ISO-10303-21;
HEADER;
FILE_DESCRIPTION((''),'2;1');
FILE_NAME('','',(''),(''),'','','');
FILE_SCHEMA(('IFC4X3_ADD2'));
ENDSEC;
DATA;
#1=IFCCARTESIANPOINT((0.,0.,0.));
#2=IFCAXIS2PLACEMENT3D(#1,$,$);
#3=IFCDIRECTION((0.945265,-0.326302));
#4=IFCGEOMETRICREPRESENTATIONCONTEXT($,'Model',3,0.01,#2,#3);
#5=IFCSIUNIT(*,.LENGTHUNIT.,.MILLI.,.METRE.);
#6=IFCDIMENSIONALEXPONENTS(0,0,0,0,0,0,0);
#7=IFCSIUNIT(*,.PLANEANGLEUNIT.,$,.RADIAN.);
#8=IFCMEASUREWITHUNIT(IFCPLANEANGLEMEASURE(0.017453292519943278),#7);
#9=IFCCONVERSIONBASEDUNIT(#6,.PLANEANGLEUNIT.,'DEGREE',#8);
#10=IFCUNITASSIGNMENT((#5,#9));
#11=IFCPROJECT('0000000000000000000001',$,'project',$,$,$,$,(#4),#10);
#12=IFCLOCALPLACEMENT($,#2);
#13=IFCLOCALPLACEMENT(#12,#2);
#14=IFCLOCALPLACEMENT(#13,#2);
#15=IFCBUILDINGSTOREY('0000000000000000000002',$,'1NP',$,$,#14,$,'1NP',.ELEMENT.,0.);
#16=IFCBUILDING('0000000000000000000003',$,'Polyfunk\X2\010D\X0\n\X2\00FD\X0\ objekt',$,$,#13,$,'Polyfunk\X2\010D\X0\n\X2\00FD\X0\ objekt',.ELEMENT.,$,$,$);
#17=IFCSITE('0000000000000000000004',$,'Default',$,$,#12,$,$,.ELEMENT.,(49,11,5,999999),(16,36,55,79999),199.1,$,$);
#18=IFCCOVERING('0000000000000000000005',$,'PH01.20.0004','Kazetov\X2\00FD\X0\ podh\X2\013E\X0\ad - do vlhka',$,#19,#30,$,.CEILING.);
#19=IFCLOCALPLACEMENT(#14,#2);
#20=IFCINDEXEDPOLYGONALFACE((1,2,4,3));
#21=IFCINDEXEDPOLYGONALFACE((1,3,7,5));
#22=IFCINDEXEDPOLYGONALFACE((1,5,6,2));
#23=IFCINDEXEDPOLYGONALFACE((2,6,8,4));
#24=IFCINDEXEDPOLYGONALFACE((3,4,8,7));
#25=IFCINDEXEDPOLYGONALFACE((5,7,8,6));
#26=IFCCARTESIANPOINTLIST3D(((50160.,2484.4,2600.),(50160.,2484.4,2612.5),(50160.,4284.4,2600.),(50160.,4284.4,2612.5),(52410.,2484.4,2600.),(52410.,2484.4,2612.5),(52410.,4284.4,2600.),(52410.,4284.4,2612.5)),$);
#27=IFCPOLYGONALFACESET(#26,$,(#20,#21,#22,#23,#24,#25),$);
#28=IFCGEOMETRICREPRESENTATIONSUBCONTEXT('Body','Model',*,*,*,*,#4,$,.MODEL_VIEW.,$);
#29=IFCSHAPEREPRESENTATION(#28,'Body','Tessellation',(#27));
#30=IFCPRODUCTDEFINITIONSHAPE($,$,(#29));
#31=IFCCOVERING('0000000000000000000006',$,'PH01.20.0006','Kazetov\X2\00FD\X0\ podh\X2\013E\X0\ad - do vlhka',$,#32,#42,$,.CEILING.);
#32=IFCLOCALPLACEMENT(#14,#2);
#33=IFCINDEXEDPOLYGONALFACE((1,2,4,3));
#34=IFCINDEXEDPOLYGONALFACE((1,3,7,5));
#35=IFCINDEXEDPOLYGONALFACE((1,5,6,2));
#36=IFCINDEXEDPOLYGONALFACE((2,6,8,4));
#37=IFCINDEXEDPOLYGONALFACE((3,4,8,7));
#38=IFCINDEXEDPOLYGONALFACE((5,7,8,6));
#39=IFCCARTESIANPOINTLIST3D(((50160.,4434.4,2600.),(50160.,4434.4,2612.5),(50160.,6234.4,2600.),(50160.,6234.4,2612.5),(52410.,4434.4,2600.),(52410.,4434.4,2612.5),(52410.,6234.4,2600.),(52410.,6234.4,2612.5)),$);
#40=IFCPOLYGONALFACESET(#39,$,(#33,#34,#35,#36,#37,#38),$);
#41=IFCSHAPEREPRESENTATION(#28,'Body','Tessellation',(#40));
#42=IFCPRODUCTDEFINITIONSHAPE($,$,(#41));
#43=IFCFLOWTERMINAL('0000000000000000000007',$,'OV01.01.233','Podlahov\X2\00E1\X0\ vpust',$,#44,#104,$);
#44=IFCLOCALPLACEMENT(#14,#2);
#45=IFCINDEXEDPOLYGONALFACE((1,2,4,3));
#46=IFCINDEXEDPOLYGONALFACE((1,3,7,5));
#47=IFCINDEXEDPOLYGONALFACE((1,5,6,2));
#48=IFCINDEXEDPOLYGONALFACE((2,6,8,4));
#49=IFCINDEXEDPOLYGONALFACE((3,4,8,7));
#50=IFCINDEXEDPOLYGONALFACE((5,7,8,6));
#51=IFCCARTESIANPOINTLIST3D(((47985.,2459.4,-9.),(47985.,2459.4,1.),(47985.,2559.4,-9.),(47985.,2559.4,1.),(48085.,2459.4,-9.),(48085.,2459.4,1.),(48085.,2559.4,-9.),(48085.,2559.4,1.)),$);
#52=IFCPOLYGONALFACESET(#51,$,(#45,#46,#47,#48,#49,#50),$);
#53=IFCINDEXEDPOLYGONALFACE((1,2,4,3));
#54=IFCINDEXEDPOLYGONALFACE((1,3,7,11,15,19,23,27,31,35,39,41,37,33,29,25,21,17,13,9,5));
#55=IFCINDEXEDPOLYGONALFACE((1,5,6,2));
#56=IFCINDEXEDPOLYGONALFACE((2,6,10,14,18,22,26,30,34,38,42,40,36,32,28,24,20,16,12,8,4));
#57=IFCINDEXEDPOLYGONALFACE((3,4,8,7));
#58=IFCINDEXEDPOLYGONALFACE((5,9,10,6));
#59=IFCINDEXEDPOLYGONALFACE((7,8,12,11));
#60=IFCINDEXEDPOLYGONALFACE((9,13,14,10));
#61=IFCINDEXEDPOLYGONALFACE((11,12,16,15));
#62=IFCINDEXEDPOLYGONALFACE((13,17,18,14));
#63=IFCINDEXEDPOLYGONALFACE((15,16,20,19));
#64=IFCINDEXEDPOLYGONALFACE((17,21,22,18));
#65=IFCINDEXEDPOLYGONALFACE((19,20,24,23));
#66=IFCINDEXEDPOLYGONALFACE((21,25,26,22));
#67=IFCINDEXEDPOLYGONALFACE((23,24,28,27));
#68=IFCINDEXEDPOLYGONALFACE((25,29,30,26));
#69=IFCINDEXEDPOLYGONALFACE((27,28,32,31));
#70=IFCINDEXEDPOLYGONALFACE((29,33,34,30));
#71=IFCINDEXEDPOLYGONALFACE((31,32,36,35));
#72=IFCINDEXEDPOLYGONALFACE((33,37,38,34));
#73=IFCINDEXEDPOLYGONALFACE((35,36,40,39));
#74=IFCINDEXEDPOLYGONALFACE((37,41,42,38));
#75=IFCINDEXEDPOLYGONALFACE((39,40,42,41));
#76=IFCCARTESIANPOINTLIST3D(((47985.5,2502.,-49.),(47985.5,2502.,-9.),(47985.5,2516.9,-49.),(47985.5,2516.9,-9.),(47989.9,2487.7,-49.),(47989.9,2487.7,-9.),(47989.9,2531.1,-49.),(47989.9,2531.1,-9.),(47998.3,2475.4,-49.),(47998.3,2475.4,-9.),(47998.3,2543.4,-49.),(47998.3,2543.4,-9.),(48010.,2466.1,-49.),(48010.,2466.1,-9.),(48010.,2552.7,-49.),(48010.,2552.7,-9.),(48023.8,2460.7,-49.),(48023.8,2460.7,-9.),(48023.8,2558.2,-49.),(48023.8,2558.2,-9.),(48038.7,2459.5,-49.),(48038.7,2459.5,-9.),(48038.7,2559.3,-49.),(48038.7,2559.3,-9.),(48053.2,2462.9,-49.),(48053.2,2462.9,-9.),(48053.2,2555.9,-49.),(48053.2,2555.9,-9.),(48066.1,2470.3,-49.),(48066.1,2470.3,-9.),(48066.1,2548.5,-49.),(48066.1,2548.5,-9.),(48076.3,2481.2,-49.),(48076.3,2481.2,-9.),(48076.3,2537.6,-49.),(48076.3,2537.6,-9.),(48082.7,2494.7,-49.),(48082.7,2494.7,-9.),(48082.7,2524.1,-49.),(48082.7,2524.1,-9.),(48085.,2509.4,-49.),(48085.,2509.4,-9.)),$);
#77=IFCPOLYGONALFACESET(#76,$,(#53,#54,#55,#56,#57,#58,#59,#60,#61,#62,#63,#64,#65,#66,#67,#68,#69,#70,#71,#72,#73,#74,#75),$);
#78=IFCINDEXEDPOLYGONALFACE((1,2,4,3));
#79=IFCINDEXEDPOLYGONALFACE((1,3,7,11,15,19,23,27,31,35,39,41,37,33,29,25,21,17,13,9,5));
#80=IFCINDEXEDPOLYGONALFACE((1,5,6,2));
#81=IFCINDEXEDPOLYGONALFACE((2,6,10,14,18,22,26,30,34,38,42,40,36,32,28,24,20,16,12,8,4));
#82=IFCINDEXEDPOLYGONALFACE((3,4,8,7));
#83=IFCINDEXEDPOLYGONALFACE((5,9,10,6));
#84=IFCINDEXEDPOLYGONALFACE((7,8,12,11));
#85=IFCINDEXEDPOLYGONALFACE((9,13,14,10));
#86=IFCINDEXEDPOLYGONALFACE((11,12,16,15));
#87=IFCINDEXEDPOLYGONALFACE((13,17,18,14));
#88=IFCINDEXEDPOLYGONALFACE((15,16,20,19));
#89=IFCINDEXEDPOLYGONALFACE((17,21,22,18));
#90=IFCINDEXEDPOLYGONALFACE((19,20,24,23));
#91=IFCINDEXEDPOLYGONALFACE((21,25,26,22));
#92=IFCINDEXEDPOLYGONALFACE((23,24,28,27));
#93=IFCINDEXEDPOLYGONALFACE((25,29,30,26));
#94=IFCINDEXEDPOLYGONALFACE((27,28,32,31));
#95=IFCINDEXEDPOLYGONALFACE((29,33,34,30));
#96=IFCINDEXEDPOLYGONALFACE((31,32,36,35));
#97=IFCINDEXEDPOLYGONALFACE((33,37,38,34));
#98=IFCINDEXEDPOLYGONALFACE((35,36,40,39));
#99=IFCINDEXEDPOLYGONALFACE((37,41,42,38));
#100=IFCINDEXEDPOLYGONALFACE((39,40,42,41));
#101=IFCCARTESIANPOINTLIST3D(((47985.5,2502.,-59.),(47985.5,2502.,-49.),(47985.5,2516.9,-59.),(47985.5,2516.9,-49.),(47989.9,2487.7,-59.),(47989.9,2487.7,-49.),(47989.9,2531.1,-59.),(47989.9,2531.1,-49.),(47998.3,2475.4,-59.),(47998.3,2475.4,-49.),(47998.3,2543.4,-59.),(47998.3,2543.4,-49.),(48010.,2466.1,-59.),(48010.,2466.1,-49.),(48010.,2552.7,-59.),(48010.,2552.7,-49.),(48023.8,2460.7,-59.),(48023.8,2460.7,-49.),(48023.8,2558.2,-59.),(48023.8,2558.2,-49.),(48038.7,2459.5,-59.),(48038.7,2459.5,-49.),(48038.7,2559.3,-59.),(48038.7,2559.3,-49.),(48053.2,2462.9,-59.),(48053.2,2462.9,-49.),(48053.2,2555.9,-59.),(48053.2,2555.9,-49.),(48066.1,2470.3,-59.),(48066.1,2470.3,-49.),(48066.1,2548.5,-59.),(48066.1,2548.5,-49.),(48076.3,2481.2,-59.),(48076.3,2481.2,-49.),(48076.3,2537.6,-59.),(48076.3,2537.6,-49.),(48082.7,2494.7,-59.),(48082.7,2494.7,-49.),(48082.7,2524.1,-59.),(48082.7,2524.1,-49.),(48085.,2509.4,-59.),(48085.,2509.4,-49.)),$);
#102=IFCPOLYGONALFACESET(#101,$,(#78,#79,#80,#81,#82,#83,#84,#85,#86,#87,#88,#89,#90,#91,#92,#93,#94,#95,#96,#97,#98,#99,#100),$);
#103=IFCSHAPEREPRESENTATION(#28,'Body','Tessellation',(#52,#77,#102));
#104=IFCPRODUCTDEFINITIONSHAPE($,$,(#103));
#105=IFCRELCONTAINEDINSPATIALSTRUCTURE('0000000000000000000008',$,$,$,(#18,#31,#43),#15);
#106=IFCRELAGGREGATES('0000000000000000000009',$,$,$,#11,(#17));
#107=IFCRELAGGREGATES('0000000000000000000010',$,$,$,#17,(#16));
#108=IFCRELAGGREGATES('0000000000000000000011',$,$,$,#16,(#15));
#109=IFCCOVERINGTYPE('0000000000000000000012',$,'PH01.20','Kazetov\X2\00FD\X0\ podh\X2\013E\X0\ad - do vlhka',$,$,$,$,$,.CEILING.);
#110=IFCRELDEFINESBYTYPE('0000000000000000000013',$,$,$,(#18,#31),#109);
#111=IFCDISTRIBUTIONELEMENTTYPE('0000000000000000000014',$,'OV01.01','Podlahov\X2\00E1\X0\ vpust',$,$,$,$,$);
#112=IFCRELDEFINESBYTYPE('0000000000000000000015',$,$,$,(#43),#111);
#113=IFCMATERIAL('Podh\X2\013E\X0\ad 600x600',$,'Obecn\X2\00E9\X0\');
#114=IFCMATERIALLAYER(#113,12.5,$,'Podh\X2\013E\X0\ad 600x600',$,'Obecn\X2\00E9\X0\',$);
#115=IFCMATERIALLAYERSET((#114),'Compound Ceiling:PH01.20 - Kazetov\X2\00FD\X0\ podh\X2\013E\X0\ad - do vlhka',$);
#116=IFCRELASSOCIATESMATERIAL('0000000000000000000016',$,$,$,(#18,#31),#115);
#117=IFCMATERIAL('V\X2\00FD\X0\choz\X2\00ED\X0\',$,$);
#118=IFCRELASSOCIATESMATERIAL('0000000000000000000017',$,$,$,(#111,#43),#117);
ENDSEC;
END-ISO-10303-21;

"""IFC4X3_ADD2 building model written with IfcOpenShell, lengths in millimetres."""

from ifc_helpers import new_model, entity, si_unit, converted_unit, direction, frame, frame_2d, origin, place, context, subcontext, project, spatial, rectangle, circle, extrude, source, transform, mapped, material, layer, layer_set, layer_usage, type_object, type_shapes, element, save


model = new_model("IFC4X3_ADD2")

# Units and contexts
model_context = context("Model", 3, precision=0.01, world=origin(), true_north=direction((0.945265, -0.326302)))
body_context = subcontext(model_context, "Body", "Model", "MODEL_VIEW")
ifc_project = project(units=[si_unit("LENGTHUNIT", "METRE", prefix="MILLI"), converted_unit("PLANEANGLEUNIT", "DEGREE", entity("IfcPlaneAngleMeasure", 0.017453292519943278), si_unit("PLANEANGLEUNIT", "RADIAN"), dimensions=[0, 0, 0, 0, 0, 0, 0])], contexts=[model_context])

# Site, building, storey
site_placement = place(None, origin())
site = spatial("IfcSite", under=ifc_project, at=site_placement, Name="Default", CompositionType="ELEMENT", RefLatitude=(49, 11, 5, 999999), RefLongitude=(16, 36, 55, 79999), RefElevation=199.1)
building_placement = place(site_placement, origin())
building = spatial("IfcBuilding", under=site, at=building_placement, Name="Polyfunkčný objekt", LongName="Polyfunkčný objekt", CompositionType="ELEMENT")
storey_placement = place(building_placement, origin())
storey = spatial("IfcBuildingStorey", under=building, at=storey_placement, Name="1NP", LongName="1NP", CompositionType="ELEMENT", Elevation=0.0)

# Coverings
ifc_material_1 = material(Name="Podhľad 600x600", Category="Obecné")
ifc_layer_1 = layer(ifc_material_1, 12.5, Name="Podhľad 600x600", Category="Obecné")
ifc_layer_set_1 = layer_set([ifc_layer_1], Name="Compound Ceiling:PH01.20 - Kazetový podhľad - do vlhka")
covering_type_1 = type_object("IfcCoveringType", Name="PH01.20", Description="Kazetový podhľad - do vlhka", PredefinedType="CEILING")
ifc_layer_usage_1 = layer_usage(ifc_layer_set_1, "AXIS3", "NEGATIVE", 0.0)
covering_1_placement = place(storey_placement, frame((50160.0, 2484.4, 2600.0)))
element("IfcCovering", 1, at=covering_1_placement, inside=storey, type_object=covering_type_1, material=ifc_layer_usage_1, Name="PH01.20.0004", Description="Kazetový podhľad - do vlhka", PredefinedType="CEILING", context=body_context, shape_type="SweptSolid", body=[
    extrude(rectangle(XDim=2250.0, YDim=1800.0, at=frame_2d((0.0, 0.0), x_axis=(1.0, 0.0))), frame((1125.0, 900.0, 0.0), z_axis=(0.0, 0.0, 1.0), x_axis=(-1.0, 0.0, 0.0)), (0.0, 0.0, 1.0), 12.5),
])
ifc_layer_usage_2 = layer_usage(ifc_layer_set_1, "AXIS3", "NEGATIVE", 0.0)
covering_2_placement = place(storey_placement, frame((50160.0, 4434.4, 2600.0)))
element("IfcCovering", 2, at=covering_2_placement, inside=storey, type_object=covering_type_1, material=ifc_layer_usage_2, Name="PH01.20.0006", Description="Kazetový podhľad - do vlhka", PredefinedType="CEILING", context=body_context, shape_type="SweptSolid", body=[
    extrude(rectangle(XDim=1800.0, YDim=2250.0, at=frame_2d((0.0, 0.0), x_axis=(1.0, 0.0))), frame((1125.0, 900.0, 0.0), z_axis=(0.0, 0.0, 1.0), x_axis=(0.0, -1.0, 0.0)), (0.0, 0.0, 1.0), 12.5),
])

# Flow terminal
ifc_material_2 = material(Name="Výchozí")
distribution_element_type = type_object("IfcDistributionElementType", Name="OV01.01", Description="Podlahová vpust", material=ifc_material_2)
shared_shape_1 = source(origin(), body_context, "Body", "SweptSolid", [
    extrude(rectangle(XDim=100.0, YDim=100.0, at=frame_2d((0.0, 0.0), x_axis=(1.0, 0.0))), frame((0.0, 0.0, -10.0), z_axis=(0.0, 0.0, 1.0), x_axis=(-1.0, 0.0, 0.0)), (0.0, 0.0, 1.0), 10.0),
    extrude(circle(Radius=50.0, at=frame_2d((0.0, 0.0), x_axis=(1.0, 0.0))), frame((0.0, 0.0, -50.0)), (0.0, 0.0, 1.0), 40.0),
    extrude(circle(Radius=50.0, at=frame_2d((0.0, 0.0), x_axis=(1.0, 0.0))), frame((0.0, 0.0, -60.0)), (0.0, 0.0, 1.0), 10.0),
])
type_shapes(distribution_element_type, [shared_shape_1])
flow_terminal_placement = place(storey_placement, frame((48035.0, 2509.4, 1.0)))
element("IfcFlowTerminal", 3, at=flow_terminal_placement, inside=storey, type_object=distribution_element_type, material=ifc_material_2, Name="OV01.01.233", Description="Podlahová vpust", context=body_context, shape_type="MappedRepresentation", body=[
    mapped(shared_shape_1, transform((0.0, 0.0, 0.0), scale=1.0)),
])

save(model, "model.ifc")
